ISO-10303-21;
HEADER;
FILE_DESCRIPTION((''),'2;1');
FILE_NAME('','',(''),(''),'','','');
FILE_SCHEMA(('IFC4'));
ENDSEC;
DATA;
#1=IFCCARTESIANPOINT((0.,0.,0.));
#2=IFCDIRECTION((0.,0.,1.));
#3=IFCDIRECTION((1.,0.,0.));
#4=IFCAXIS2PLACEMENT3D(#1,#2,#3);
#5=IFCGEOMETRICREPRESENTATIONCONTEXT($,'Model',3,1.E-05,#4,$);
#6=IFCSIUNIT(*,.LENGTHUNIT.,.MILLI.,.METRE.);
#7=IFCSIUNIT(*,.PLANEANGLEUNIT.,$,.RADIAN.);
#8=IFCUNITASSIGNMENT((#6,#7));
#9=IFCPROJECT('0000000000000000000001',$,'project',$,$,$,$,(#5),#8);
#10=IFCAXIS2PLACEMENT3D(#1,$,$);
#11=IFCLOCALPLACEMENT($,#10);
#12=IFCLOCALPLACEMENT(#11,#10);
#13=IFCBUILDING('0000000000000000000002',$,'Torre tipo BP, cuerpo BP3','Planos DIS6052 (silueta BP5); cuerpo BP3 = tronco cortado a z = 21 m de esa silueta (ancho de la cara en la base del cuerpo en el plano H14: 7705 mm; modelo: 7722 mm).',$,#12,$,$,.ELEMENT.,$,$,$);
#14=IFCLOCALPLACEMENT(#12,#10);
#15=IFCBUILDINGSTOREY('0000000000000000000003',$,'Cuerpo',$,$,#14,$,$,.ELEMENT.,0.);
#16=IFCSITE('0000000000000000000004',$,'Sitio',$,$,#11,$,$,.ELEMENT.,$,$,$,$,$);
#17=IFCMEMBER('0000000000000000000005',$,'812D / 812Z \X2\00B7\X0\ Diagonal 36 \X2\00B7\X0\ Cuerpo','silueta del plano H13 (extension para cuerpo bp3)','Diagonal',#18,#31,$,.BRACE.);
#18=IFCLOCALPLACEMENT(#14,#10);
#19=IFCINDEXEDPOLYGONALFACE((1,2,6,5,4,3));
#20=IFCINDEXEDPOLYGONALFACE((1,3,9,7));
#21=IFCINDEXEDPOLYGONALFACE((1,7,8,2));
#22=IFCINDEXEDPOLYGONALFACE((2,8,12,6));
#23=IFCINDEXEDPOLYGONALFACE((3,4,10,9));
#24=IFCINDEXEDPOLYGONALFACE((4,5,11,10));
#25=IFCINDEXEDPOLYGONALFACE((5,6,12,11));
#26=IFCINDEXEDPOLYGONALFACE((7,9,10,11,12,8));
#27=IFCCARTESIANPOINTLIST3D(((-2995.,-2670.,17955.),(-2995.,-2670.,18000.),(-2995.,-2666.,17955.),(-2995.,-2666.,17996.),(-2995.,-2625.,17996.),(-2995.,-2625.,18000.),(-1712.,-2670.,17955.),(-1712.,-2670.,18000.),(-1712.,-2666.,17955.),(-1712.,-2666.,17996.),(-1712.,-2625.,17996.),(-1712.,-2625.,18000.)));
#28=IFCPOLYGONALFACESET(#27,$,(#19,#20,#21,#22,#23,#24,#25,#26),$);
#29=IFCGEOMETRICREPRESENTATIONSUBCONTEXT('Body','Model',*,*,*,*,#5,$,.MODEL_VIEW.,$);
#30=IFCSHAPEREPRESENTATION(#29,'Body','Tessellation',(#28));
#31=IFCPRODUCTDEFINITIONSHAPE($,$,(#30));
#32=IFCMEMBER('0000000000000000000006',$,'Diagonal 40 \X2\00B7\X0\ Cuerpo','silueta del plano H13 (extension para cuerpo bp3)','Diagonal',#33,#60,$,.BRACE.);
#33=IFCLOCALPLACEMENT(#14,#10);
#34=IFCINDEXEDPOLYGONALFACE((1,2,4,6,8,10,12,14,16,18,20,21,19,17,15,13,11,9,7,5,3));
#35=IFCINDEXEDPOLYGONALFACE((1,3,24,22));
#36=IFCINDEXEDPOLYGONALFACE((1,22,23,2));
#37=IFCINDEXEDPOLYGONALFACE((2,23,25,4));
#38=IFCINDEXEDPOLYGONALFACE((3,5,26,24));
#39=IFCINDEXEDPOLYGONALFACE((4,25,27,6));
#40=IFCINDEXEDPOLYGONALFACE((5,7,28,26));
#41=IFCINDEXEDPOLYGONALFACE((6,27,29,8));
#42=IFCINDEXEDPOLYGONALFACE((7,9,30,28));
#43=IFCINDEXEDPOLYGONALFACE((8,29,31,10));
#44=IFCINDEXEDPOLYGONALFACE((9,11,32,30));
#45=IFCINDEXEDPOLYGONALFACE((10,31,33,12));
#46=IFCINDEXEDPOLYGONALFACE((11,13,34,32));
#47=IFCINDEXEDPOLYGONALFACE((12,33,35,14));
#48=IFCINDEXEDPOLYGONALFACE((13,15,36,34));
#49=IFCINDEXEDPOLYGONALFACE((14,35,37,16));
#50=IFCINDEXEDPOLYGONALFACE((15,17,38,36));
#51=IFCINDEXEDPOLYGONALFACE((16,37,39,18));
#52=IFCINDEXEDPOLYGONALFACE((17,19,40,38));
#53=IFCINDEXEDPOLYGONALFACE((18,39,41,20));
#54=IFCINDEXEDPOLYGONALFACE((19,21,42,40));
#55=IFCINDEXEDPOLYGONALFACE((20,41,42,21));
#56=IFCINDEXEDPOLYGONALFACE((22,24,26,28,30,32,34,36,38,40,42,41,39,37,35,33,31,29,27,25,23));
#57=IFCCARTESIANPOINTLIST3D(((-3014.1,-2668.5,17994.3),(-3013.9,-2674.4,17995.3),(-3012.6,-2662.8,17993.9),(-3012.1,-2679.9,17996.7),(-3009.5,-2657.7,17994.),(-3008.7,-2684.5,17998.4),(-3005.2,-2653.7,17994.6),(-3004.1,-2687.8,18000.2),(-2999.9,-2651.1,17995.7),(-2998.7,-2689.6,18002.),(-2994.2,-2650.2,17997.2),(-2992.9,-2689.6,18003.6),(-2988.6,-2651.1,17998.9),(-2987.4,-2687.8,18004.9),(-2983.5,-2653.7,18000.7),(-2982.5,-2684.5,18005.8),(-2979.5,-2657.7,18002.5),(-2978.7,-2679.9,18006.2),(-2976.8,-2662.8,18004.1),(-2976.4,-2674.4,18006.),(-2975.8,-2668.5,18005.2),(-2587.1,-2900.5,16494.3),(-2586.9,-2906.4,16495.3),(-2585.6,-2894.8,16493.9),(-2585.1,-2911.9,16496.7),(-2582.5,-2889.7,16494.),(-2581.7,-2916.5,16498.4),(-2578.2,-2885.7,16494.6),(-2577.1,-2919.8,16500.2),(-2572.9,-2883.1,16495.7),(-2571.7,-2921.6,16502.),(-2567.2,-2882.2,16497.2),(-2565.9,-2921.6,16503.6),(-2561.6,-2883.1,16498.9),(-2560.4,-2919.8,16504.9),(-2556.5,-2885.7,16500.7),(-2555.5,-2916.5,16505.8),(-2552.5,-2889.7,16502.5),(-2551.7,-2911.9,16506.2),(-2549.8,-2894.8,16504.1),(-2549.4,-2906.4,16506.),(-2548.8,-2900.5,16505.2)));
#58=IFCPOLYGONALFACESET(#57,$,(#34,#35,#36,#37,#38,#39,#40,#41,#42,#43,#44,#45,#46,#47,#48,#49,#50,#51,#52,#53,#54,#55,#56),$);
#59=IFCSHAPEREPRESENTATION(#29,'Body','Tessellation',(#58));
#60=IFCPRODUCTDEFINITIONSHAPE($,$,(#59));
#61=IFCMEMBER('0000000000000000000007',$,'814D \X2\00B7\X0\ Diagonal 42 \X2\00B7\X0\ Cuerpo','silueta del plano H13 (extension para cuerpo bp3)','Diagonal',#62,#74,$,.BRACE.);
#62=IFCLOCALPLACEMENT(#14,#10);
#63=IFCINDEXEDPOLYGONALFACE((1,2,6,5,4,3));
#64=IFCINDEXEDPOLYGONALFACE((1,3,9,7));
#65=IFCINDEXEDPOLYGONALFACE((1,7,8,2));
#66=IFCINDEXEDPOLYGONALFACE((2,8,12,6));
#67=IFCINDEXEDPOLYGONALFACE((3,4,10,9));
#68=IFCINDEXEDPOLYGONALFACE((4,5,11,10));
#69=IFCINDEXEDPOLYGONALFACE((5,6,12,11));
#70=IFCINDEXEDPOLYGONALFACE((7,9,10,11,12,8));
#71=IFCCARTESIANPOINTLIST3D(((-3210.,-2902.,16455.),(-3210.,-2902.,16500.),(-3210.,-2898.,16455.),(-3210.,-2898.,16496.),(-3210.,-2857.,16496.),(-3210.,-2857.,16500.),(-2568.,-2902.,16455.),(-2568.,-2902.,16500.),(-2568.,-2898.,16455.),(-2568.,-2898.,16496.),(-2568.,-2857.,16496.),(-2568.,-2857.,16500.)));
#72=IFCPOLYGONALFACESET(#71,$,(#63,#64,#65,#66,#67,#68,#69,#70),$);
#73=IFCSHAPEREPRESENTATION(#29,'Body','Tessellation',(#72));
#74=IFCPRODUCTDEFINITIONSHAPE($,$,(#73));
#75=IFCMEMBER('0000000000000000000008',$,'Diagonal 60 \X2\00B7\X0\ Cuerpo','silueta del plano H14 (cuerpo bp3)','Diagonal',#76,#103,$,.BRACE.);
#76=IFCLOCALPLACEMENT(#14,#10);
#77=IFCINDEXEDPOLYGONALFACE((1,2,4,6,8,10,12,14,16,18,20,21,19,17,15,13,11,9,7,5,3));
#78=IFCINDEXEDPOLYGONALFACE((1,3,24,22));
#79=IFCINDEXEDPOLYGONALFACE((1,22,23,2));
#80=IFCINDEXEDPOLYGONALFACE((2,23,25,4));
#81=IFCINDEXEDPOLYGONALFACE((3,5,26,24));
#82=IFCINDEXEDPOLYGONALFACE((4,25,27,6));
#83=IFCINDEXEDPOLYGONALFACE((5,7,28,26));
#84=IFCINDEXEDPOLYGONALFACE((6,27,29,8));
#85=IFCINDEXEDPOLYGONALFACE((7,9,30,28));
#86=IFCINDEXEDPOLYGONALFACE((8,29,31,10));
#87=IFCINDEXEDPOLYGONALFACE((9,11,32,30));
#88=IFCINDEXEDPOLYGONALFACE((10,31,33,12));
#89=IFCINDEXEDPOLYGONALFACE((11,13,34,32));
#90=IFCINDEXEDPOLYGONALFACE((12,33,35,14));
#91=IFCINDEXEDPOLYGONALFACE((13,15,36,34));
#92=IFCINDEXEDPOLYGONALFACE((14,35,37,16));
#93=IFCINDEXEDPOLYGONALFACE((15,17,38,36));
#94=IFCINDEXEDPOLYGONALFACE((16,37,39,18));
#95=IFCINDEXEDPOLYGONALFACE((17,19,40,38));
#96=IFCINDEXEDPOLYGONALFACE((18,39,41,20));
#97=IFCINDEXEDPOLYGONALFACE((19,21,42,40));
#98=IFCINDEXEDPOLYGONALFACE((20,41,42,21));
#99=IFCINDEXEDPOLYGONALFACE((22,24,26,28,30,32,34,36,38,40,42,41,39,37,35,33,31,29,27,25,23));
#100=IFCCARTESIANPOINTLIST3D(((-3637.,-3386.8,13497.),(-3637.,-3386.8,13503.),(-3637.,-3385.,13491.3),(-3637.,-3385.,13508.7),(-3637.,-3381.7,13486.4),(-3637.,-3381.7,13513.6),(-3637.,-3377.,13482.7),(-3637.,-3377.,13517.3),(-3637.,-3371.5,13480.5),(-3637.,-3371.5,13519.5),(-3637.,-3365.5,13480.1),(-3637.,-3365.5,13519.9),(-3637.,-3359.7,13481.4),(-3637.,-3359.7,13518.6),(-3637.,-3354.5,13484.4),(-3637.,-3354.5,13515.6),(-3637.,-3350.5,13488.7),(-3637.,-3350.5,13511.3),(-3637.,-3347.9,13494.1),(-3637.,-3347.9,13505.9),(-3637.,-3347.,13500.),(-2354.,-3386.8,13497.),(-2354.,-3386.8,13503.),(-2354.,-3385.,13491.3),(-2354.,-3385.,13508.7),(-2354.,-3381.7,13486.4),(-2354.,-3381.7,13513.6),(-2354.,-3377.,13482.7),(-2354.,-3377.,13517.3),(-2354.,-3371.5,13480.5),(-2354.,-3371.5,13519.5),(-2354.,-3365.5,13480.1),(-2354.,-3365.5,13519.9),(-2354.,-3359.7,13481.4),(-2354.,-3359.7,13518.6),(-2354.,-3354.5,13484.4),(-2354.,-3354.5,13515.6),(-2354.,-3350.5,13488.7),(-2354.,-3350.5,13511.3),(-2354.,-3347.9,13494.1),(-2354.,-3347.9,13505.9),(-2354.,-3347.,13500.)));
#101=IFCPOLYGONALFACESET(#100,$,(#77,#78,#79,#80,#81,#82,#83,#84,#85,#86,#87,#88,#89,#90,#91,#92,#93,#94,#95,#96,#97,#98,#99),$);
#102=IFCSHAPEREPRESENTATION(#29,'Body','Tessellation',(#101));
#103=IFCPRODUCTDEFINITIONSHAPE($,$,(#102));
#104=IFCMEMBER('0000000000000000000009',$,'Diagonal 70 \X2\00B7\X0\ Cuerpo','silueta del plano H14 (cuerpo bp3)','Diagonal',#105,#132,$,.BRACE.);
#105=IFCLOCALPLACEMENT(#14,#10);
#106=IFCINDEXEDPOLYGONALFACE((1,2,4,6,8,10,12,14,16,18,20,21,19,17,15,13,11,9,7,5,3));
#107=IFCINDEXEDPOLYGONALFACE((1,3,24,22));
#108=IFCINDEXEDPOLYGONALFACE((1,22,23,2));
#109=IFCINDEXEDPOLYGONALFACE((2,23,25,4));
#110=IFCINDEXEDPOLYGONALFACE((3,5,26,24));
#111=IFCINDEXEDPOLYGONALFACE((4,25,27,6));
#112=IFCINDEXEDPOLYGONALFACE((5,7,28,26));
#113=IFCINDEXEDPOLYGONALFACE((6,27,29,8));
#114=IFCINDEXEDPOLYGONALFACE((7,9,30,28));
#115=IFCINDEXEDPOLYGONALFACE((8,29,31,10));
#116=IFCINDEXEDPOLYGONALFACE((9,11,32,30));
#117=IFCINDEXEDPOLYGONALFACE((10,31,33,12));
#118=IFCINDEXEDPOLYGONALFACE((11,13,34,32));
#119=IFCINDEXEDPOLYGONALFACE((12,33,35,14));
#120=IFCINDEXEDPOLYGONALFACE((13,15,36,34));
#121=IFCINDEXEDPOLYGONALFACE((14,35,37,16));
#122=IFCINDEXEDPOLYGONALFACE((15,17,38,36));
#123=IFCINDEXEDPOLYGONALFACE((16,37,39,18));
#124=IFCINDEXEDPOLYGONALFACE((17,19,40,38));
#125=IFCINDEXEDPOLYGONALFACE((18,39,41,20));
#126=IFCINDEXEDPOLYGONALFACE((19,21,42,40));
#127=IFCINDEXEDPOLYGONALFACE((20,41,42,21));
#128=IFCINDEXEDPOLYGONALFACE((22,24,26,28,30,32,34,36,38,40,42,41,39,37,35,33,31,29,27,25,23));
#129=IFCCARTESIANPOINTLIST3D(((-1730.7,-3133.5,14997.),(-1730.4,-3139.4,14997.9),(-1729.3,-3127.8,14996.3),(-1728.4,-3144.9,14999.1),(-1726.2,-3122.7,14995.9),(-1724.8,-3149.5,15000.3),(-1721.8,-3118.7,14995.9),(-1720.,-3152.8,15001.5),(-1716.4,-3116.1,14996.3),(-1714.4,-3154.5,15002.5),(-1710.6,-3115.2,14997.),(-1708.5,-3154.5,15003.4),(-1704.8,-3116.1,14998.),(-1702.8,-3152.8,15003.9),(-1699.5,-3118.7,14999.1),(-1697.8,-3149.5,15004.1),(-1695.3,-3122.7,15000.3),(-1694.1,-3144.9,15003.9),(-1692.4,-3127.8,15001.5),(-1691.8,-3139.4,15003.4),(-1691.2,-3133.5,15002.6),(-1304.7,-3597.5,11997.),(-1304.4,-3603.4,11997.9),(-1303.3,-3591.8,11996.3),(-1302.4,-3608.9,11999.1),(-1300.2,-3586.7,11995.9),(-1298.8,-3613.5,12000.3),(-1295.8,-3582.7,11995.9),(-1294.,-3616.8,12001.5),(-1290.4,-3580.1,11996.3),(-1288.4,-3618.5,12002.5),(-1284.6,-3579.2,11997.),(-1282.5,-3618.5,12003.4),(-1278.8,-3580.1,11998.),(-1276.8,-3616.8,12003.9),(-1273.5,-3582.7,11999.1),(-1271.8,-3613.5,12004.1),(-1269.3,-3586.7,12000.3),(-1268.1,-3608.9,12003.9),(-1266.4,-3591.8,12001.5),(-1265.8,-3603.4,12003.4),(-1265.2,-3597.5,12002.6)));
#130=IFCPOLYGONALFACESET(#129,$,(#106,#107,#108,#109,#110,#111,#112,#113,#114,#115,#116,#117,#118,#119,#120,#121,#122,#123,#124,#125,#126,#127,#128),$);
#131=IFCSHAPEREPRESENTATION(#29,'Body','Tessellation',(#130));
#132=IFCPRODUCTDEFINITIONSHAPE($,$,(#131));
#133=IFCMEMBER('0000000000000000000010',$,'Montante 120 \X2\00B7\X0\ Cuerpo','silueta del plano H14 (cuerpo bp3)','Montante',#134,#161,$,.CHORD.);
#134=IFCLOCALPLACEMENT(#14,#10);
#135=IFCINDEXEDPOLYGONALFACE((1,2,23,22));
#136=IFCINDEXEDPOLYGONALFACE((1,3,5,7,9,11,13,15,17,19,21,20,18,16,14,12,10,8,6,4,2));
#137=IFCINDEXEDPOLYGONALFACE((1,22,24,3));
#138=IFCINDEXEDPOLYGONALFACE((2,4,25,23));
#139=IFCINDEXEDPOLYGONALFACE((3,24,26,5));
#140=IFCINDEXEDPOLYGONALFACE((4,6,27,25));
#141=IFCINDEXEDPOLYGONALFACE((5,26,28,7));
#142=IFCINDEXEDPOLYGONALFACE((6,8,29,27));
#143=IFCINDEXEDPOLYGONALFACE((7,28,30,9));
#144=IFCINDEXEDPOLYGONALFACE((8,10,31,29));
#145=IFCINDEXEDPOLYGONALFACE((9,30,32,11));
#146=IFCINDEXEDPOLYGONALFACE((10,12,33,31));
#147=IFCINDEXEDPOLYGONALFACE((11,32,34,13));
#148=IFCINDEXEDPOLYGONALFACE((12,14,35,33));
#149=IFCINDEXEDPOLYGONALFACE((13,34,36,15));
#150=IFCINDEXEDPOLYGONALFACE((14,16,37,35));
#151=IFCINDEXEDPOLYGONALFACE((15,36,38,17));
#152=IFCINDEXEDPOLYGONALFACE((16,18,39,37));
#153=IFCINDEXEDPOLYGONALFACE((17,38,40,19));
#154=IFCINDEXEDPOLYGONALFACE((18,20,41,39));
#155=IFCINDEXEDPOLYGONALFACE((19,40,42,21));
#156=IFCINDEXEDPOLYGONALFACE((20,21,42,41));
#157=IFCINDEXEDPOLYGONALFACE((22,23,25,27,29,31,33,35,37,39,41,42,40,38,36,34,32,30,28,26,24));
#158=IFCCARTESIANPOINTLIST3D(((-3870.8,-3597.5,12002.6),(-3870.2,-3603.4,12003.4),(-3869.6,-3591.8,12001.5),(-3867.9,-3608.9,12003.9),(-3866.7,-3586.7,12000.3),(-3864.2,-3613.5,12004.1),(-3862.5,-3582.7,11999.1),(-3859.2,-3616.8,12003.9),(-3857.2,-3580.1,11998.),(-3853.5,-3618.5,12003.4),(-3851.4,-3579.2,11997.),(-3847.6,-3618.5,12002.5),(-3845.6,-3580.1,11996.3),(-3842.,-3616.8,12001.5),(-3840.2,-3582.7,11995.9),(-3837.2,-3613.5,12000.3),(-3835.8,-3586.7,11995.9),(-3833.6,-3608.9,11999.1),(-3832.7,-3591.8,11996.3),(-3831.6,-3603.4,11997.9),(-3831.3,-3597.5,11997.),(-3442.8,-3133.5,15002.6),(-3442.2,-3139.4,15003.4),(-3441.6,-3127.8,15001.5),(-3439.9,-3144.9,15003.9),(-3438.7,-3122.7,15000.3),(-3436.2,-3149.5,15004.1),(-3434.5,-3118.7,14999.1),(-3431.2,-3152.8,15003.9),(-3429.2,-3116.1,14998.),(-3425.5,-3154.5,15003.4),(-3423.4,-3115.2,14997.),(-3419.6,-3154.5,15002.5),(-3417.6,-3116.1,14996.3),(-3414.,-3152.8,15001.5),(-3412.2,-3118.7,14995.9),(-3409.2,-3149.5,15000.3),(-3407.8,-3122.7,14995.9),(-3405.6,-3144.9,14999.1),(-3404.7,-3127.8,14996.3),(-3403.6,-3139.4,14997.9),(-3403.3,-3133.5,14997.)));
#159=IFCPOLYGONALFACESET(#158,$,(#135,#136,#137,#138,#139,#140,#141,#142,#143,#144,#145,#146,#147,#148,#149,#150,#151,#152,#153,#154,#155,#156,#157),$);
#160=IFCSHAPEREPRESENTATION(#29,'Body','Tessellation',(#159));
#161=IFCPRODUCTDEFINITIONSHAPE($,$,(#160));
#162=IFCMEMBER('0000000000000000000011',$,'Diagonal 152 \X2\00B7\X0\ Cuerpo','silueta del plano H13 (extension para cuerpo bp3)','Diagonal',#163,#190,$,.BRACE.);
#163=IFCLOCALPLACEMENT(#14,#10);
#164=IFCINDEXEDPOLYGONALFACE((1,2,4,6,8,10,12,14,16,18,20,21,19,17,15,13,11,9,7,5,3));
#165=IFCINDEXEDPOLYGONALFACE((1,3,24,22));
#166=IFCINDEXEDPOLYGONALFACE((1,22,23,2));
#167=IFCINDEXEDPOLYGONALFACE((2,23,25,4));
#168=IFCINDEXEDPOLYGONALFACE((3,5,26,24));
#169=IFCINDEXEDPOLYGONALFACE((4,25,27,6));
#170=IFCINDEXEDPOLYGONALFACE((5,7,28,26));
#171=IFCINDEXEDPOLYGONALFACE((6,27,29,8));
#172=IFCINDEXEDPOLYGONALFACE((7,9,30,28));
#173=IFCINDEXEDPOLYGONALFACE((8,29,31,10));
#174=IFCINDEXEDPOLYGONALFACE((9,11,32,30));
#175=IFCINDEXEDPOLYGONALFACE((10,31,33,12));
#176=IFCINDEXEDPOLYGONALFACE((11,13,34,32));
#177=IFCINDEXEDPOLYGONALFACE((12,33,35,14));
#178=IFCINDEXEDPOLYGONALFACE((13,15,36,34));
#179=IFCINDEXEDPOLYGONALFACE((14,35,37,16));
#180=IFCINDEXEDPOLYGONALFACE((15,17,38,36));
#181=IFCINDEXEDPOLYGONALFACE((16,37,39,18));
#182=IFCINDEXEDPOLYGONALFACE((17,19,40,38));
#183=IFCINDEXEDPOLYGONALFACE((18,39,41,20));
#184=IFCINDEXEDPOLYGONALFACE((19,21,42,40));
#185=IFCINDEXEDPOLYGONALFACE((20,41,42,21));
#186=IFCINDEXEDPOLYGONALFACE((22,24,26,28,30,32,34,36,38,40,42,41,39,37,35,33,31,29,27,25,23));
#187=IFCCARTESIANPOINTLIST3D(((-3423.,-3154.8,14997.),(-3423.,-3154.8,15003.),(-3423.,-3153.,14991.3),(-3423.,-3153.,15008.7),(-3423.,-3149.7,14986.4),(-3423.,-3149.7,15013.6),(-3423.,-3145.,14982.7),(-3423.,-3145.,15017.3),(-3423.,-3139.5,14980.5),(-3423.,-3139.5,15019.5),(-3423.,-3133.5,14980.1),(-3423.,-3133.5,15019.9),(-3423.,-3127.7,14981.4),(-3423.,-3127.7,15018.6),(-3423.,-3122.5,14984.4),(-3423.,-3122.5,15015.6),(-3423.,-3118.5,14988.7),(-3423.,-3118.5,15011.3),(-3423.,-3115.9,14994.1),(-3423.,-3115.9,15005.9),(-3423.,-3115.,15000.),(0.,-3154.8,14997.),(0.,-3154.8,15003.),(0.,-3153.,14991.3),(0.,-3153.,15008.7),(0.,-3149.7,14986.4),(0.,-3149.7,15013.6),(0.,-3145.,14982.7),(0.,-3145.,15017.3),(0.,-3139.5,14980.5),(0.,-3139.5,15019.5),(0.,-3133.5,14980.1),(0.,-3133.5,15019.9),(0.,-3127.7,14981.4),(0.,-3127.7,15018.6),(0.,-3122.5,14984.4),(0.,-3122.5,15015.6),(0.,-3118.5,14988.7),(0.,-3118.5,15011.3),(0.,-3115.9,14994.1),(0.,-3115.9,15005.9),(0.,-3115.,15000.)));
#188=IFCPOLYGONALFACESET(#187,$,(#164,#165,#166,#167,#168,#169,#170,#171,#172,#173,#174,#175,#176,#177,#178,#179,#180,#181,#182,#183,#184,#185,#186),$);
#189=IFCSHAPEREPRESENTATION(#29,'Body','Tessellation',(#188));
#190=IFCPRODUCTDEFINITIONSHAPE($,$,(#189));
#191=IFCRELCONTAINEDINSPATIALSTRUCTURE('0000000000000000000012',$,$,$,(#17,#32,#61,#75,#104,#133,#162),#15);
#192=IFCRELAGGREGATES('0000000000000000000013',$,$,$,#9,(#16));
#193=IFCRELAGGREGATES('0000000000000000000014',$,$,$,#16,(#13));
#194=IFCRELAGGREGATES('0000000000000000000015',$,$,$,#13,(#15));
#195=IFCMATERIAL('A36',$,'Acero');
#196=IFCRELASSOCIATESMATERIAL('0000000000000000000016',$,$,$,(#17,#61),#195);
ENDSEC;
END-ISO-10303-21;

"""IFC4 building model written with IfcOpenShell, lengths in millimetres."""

from ifc_helpers import new_model, si_unit, frame, frame_2d, origin, origin_with_axes, place, context, subcontext, project, spatial, circle, l_section, extrude, material, element, save


model = new_model("IFC4")

# Units and contexts
model_context = context("Model", 3, precision=1e-05, world=origin_with_axes())
body_context = subcontext(model_context, "Body", "Model", "MODEL_VIEW")
ifc_project = project(units=[si_unit("LENGTHUNIT", "METRE", prefix="MILLI"), si_unit("PLANEANGLEUNIT", "RADIAN")], contexts=[model_context])

# Site, building, storey
site_placement = place(None, origin())
site = spatial("IfcSite", under=ifc_project, at=site_placement, Name="Sitio", CompositionType="ELEMENT")
building_placement = place(site_placement, origin())
building = spatial("IfcBuilding", under=site, at=building_placement, Name="Torre tipo BP, cuerpo BP3", Description="Planos DIS6052 (silueta BP5); cuerpo BP3 = tronco cortado a z = 21 m de esa silueta (ancho de la cara en la base del cuerpo en el plano H14: 7705 mm; modelo: 7722 mm).", CompositionType="ELEMENT")
storey_placement = place(building_placement, origin())
storey = spatial("IfcBuildingStorey", under=building, at=storey_placement, Name="Cuerpo", CompositionType="ELEMENT", Elevation=0.0)

# Members
ifc_material = material(Name="A36", Category="Acero")
member_1_placement = place(storey_placement, frame((-1712.0, -2670.0, 18000.0), z_axis=(-1.0, 0.0, 0.0), x_axis=(0.0, 1.0, 0.0)))
element("IfcMember", 1, at=member_1_placement, inside=storey, material=ifc_material, Name="812D / 812Z · Diagonal 36 · Cuerpo", Description="silueta del plano H13 (extension para cuerpo bp3)", ObjectType="Diagonal", PredefinedType="BRACE", context=body_context, shape_type="SweptSolid", body=[
    extrude(l_section(Depth=45.0, Width=45.0, Thickness=4.0, at=frame_2d((22.5, 22.5))), None, (0.0, 0.0, 1.0), 1283.0),
])
member_2_placement = place(storey_placement, frame((-2568.0, -2902.0, 16500.0), z_axis=(-0.27081, 0.147138, 0.951322), x_axis=(0.040285, 0.989116, -0.141516)))
element("IfcMember", 2, at=member_2_placement, inside=storey, Name="Diagonal 40 · Cuerpo", Description="silueta del plano H13 (extension para cuerpo bp3)", ObjectType="Diagonal", PredefinedType="BRACE", context=body_context, shape_type="SweptSolid", body=[
    extrude(circle(Radius=20.0), None, (0.0, 0.0, 1.0), 1576.8),
])
member_3_placement = place(storey_placement, frame((-2568.0, -2902.0, 16500.0), z_axis=(-1.0, 0.0, 0.0), x_axis=(0.0, 1.0, 0.0)))
element("IfcMember", 3, at=member_3_placement, inside=storey, material=ifc_material, Name="814D · Diagonal 42 · Cuerpo", Description="silueta del plano H13 (extension para cuerpo bp3)", ObjectType="Diagonal", PredefinedType="BRACE", context=body_context, shape_type="SweptSolid", body=[
    extrude(l_section(Depth=45.0, Width=45.0, Thickness=4.0, at=frame_2d((22.5, 22.5))), None, (0.0, 0.0, 1.0), 642.0),
])
member_4_placement = place(storey_placement, frame((-2354.0, -3367.0, 13500.0), z_axis=(-1.0, 0.0, 0.0), x_axis=(0.0, 1.0, 0.0)))
element("IfcMember", 4, at=member_4_placement, inside=storey, Name="Diagonal 60 · Cuerpo", Description="silueta del plano H14 (cuerpo bp3)", ObjectType="Diagonal", PredefinedType="BRACE", context=body_context, shape_type="SweptSolid", body=[
    extrude(circle(Radius=20.0), None, (0.0, 0.0, 1.0), 1283.0),
])
member_5_placement = place(storey_placement, frame((-1711.0, -3135.0, 15000.0), z_axis=(0.13897, -0.151366, -0.97866), x_axis=(0.021281, 0.988478, -0.149863)))
element("IfcMember", 5, at=member_5_placement, inside=storey, Name="Diagonal 70 · Cuerpo", Description="silueta del plano H14 (cuerpo bp3)", ObjectType="Diagonal", PredefinedType="BRACE", context=body_context, shape_type="SweptSolid", body=[
    extrude(circle(Radius=20.0), None, (0.0, 0.0, 1.0), 3065.4),
])
member_6_placement = place(storey_placement, frame((-3423.0, -3135.0, 15000.0), z_axis=(-0.139609, -0.151352, -0.978571), x_axis=(-0.021376, 0.98848, -0.149835)))
element("IfcMember", 6, at=member_6_placement, inside=storey, Name="Montante 120 · Cuerpo", Description="silueta del plano H14 (cuerpo bp3)", ObjectType="Montante", PredefinedType="CHORD", context=body_context, shape_type="SweptSolid", body=[
    extrude(circle(Radius=20.0), None, (0.0, 0.0, 1.0), 3065.7),
])
member_7_placement = place(storey_placement, frame((-3423.0, -3135.0, 15000.0), z_axis=(1.0, 0.0, 0.0), x_axis=(0.0, 1.0, 0.0)))
element("IfcMember", 7, at=member_7_placement, inside=storey, Name="Diagonal 152 · Cuerpo", Description="silueta del plano H13 (extension para cuerpo bp3)", ObjectType="Diagonal", PredefinedType="BRACE", context=body_context, shape_type="SweptSolid", body=[
    extrude(circle(Radius=20.0), None, (0.0, 0.0, 1.0), 3423.0),
])

save(model, "model.ifc")
